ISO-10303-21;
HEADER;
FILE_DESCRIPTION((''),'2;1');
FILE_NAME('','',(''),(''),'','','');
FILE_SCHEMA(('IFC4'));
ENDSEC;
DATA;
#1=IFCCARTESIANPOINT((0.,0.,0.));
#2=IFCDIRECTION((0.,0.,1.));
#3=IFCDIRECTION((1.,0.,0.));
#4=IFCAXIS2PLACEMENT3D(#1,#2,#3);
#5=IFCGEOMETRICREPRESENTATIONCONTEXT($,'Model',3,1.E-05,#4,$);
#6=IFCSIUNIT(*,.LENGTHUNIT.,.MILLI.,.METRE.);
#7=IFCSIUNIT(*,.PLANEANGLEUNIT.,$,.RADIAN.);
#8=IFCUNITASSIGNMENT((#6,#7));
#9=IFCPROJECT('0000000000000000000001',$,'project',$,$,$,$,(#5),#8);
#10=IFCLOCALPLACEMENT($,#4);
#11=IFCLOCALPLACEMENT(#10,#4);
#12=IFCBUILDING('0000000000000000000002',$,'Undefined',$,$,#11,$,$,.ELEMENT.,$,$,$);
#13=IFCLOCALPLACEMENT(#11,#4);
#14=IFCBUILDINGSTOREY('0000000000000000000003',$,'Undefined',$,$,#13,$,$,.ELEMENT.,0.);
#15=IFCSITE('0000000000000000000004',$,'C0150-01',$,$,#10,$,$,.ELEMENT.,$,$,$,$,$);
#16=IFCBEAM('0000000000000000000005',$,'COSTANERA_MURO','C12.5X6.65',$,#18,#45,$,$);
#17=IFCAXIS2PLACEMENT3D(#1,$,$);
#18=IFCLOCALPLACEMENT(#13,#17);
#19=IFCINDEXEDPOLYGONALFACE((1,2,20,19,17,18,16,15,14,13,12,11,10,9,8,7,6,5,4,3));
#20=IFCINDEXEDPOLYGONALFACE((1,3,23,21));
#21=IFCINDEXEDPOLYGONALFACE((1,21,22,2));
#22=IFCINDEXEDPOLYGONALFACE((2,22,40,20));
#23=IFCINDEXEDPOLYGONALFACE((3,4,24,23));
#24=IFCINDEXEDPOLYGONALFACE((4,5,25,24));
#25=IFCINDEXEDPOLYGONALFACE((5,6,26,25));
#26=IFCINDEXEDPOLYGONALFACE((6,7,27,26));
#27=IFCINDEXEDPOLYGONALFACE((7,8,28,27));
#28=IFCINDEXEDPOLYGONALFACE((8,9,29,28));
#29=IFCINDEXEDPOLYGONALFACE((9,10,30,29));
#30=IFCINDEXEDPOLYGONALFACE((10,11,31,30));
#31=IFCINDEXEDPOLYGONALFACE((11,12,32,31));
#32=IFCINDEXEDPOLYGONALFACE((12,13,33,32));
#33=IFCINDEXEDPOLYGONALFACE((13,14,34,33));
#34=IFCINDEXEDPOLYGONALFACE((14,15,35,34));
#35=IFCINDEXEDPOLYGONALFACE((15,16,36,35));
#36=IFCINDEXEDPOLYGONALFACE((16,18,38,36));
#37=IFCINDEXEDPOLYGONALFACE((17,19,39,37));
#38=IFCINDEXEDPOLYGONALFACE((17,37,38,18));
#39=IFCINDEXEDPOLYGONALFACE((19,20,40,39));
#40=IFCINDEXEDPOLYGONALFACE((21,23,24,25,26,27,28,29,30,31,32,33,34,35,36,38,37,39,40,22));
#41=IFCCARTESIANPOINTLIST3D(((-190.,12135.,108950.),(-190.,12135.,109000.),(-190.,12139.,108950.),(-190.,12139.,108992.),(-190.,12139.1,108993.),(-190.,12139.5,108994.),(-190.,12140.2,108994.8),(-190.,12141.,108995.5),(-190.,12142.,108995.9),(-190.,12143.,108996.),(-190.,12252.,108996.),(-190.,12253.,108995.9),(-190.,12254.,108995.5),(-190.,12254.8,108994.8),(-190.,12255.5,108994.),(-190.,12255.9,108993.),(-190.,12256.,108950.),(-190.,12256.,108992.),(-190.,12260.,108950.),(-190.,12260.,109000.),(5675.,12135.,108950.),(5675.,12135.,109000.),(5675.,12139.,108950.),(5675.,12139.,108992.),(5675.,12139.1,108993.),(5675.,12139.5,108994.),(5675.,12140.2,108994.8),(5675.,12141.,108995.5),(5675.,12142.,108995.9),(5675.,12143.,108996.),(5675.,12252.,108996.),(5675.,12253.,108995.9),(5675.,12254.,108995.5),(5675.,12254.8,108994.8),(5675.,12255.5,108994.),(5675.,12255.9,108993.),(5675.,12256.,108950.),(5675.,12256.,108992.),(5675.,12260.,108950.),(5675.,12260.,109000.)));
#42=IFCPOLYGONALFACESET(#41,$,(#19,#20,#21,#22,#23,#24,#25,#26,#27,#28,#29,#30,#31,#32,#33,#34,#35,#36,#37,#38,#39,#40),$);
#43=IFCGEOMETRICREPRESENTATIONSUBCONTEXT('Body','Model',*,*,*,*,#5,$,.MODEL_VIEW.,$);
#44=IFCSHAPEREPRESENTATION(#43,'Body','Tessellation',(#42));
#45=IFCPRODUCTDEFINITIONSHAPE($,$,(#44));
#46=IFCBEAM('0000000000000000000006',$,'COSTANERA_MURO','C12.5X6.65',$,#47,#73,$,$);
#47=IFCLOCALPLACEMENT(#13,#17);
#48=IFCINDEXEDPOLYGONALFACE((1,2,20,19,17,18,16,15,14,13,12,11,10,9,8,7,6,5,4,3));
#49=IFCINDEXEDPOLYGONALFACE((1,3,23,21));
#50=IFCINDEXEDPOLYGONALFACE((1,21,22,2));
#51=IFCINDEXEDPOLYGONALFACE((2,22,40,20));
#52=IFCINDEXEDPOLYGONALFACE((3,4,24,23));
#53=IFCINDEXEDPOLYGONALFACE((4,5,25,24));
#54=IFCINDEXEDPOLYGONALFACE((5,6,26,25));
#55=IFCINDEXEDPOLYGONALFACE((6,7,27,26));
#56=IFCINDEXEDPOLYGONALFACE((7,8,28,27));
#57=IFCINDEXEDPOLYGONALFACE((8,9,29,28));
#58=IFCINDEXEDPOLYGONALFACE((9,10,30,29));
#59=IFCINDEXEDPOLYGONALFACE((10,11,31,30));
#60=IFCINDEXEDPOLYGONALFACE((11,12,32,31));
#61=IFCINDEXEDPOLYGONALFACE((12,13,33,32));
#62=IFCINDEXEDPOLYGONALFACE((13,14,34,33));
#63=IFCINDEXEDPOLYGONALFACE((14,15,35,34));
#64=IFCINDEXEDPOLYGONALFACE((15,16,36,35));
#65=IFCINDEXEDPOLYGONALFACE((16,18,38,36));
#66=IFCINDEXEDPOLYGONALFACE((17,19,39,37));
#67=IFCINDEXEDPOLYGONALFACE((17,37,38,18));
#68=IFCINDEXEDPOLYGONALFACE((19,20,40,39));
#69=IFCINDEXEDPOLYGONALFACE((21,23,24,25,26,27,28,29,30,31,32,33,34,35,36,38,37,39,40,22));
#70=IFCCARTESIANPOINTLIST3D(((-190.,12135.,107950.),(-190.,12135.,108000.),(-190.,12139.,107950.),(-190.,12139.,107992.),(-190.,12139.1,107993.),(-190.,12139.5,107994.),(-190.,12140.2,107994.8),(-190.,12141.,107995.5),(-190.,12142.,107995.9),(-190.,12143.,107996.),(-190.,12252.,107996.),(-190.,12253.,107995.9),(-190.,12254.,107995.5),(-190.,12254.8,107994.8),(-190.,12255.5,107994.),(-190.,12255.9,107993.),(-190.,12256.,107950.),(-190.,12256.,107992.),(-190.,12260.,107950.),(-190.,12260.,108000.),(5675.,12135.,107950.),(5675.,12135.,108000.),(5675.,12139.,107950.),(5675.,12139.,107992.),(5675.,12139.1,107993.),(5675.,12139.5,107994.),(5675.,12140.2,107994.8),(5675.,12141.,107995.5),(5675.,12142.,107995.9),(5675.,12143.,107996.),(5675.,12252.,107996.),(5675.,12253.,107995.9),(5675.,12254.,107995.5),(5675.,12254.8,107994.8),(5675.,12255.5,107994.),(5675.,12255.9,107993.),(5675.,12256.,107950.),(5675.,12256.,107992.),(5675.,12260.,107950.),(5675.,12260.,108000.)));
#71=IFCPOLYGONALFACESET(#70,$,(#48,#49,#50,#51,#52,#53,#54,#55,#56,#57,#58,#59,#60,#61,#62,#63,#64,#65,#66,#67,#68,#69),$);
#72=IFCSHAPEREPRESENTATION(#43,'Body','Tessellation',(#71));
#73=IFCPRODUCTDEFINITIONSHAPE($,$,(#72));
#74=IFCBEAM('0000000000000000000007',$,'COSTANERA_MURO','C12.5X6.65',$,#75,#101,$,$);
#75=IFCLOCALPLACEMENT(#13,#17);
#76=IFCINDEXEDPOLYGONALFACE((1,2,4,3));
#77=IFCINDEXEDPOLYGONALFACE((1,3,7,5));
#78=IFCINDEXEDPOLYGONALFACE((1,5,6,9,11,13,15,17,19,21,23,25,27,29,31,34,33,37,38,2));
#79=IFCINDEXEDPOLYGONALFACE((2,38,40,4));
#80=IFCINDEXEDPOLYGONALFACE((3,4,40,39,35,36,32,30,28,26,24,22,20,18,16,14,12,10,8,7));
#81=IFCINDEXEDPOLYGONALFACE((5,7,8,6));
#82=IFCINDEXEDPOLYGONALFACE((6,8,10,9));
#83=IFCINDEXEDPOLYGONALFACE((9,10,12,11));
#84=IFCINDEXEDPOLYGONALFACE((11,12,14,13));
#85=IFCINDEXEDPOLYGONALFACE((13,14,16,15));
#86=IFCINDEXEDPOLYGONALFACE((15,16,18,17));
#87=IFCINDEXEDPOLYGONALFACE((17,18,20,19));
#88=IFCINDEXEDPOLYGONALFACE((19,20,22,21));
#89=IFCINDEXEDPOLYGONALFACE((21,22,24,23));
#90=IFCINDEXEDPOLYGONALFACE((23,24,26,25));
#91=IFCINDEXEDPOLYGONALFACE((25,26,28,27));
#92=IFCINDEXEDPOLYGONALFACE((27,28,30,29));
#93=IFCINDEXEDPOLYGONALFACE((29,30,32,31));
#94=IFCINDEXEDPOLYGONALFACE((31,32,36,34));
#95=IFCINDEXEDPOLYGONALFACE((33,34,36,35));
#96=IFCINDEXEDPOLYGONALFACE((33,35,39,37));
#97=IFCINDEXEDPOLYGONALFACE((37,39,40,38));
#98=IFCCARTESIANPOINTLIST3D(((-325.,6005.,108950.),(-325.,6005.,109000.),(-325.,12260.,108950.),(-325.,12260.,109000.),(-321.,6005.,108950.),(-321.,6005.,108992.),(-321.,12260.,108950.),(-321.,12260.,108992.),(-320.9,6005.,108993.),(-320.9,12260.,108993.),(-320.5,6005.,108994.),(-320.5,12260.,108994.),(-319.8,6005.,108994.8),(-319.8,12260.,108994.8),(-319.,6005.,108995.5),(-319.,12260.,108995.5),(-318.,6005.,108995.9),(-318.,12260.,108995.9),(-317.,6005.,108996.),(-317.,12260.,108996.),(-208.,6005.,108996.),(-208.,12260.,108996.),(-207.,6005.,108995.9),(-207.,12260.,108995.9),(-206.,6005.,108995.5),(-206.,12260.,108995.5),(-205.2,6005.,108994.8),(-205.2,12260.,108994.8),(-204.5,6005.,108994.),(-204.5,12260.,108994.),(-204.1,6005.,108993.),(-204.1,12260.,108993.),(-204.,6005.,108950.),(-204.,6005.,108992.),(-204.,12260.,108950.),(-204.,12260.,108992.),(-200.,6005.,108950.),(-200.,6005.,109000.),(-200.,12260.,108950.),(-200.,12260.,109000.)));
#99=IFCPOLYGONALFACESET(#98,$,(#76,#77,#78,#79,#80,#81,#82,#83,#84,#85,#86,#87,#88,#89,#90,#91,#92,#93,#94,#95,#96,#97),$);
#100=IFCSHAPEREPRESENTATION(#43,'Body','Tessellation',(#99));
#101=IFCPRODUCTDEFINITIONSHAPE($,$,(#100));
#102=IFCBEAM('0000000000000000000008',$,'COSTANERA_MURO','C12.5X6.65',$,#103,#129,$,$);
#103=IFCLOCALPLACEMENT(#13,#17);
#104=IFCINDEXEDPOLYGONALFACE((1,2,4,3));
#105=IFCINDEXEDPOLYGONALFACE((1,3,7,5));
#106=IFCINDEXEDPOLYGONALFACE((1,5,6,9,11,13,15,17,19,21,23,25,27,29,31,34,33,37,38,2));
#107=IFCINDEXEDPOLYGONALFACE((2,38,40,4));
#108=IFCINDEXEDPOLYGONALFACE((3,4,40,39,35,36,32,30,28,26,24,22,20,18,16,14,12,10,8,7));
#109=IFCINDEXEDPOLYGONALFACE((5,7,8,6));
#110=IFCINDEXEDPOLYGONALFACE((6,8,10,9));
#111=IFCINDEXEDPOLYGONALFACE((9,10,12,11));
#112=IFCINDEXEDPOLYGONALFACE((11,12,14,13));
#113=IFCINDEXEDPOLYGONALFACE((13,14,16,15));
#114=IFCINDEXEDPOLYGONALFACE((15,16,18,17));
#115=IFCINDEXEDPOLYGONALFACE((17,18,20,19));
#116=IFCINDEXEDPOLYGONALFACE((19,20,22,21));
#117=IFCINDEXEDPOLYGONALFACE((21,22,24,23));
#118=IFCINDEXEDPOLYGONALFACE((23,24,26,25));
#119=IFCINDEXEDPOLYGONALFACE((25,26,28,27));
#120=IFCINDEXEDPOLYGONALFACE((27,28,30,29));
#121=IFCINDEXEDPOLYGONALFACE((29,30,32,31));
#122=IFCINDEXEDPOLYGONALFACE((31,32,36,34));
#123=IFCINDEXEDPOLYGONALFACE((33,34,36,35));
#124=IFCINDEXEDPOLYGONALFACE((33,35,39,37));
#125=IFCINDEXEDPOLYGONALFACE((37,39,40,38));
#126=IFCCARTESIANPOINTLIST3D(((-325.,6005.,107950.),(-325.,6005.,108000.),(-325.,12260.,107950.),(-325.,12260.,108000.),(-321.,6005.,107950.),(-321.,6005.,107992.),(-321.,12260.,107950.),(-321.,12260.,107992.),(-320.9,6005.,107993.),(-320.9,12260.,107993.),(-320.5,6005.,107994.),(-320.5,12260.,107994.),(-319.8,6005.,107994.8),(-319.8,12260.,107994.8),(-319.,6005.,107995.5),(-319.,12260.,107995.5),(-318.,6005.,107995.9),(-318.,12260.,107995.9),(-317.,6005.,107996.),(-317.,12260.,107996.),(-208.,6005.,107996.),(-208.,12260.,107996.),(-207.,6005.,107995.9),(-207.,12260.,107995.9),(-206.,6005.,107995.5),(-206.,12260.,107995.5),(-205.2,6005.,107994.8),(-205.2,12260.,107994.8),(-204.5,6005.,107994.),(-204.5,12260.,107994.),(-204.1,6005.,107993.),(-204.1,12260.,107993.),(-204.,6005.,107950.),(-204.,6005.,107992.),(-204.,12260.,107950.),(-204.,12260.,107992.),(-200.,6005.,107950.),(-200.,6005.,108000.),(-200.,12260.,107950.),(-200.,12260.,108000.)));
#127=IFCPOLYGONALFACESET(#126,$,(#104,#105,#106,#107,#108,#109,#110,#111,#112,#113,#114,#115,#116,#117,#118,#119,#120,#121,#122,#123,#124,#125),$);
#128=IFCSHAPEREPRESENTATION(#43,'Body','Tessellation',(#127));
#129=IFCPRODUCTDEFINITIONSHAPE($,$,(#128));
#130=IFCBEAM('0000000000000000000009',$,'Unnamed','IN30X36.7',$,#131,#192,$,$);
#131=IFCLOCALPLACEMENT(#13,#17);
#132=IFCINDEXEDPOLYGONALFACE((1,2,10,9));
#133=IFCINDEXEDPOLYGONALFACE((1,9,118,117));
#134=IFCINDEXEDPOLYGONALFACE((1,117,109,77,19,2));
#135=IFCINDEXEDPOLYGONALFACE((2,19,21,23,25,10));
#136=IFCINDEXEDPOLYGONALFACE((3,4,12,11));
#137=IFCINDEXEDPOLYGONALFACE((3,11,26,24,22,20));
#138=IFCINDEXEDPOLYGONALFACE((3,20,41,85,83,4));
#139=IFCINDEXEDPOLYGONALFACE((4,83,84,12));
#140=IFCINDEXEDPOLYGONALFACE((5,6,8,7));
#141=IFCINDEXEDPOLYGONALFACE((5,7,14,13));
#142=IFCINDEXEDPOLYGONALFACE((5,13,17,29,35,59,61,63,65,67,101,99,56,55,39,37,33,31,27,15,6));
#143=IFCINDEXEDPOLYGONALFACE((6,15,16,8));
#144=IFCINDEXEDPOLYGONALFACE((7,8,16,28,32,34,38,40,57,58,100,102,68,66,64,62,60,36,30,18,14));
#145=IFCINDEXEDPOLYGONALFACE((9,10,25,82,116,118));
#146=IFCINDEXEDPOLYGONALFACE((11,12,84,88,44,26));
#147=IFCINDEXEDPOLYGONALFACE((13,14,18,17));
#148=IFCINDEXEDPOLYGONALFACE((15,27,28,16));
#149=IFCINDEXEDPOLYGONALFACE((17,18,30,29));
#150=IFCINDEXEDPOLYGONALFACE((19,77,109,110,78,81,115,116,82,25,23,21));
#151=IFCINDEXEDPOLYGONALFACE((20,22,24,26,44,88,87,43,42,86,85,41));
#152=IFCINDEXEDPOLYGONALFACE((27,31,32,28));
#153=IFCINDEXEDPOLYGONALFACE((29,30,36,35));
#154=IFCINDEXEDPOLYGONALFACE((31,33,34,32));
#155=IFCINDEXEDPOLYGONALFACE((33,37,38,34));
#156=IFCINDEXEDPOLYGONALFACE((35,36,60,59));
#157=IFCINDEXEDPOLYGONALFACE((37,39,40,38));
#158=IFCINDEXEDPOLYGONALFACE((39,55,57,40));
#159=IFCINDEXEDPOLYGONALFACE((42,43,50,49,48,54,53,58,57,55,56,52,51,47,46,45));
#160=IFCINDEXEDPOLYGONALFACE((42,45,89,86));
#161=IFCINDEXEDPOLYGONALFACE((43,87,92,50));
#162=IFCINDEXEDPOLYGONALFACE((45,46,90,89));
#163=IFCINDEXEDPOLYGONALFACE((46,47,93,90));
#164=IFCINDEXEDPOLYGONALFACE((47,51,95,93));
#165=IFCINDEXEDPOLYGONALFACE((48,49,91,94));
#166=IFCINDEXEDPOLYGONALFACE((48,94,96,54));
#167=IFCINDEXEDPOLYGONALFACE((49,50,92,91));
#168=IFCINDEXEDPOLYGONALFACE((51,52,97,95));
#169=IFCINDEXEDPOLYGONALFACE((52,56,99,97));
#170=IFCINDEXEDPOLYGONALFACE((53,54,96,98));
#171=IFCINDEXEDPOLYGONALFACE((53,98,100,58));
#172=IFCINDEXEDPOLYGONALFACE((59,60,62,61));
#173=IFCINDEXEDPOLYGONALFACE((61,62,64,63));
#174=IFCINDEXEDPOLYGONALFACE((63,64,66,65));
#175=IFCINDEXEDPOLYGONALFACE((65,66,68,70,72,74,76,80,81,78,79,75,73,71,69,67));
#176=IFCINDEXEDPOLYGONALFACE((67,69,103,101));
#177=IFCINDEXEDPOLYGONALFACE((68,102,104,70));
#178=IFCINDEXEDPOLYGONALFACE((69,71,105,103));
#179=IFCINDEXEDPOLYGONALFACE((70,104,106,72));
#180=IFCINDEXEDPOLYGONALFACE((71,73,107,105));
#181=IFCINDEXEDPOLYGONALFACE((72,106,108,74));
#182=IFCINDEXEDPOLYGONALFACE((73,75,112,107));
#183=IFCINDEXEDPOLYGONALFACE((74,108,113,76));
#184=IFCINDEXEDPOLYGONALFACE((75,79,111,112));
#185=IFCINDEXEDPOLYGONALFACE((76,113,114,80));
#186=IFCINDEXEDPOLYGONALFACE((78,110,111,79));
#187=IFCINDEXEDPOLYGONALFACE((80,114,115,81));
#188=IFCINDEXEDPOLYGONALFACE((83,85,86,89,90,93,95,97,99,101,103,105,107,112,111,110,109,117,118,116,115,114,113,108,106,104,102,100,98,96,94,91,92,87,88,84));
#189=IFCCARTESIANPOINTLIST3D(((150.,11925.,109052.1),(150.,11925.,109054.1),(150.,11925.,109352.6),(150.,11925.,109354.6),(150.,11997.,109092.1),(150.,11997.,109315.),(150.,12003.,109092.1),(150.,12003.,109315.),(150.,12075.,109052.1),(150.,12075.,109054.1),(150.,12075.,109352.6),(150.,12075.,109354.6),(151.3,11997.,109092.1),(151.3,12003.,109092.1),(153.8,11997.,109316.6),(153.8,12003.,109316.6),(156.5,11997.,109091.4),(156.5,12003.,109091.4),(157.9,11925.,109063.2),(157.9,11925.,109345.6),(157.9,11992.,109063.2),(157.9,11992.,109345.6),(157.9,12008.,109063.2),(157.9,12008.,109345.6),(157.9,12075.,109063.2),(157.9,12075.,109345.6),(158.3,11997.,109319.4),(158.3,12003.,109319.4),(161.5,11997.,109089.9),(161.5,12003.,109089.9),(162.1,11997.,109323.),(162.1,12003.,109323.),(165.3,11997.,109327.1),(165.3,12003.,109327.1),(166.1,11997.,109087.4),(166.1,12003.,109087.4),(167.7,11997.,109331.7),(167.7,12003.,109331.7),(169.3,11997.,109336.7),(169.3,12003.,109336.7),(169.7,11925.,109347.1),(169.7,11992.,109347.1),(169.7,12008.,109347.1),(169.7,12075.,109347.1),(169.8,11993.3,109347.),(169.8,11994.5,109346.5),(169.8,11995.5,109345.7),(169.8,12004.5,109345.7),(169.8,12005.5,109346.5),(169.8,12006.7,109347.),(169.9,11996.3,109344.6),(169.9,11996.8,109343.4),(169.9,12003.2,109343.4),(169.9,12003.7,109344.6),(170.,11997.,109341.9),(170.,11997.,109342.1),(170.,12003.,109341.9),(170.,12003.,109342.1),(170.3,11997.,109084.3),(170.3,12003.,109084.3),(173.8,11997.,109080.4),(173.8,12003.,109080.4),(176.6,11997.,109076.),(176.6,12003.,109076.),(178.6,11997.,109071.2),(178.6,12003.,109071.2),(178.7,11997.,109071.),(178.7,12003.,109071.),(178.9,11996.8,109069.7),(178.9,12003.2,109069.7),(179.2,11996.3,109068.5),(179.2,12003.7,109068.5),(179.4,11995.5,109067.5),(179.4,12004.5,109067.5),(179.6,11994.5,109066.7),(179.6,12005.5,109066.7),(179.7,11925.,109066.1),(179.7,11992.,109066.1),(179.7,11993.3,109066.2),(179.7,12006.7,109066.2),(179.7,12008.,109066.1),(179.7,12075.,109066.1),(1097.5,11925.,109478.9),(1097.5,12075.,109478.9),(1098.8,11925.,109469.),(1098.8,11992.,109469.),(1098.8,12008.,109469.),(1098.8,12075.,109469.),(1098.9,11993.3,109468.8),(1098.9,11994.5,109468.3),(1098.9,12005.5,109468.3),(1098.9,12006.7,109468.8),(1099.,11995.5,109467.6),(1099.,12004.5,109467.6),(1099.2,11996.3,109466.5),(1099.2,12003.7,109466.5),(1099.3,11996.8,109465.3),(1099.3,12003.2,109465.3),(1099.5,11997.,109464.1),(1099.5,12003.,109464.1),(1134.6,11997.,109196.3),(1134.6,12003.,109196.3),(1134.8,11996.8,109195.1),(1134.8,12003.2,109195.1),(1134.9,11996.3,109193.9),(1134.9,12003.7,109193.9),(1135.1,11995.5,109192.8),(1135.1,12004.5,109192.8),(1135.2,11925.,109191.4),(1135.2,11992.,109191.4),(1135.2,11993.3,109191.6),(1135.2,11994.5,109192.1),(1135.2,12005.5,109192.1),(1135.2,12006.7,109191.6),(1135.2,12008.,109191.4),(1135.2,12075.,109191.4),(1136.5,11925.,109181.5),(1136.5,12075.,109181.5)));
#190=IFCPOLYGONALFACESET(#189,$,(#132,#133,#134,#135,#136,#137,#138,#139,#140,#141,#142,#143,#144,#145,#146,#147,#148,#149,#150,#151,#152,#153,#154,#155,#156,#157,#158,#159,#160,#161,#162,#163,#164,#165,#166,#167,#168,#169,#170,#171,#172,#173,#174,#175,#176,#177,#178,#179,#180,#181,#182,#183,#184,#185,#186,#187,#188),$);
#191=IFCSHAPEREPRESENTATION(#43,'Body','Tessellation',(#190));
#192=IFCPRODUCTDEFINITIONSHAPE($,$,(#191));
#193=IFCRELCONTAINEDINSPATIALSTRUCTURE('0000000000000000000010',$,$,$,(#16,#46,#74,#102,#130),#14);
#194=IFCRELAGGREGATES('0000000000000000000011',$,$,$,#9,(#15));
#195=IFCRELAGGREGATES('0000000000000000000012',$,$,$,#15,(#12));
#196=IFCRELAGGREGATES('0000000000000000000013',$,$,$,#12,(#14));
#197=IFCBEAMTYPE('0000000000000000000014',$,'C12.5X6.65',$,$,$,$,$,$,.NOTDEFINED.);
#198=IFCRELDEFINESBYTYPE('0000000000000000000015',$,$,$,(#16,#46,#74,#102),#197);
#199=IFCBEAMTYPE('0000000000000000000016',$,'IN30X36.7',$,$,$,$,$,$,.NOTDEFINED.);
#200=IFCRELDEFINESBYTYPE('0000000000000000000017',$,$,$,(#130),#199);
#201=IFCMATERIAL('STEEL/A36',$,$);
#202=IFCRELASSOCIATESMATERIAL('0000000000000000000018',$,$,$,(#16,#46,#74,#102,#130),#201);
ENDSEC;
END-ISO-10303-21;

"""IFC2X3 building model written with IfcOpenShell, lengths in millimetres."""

from ifc_helpers import new_model, si_unit, frame, origin_with_axes, origin_2d_with_axis, place, context, subcontext, project, spatial, polyline, i_section, u_section, outline, extrude, boolean, halfspace, material, type_object, element, save


model = new_model("IFC2X3")

# Units and contexts
model_context = context("Model", 3, precision=1e-05, world=origin_with_axes())
body_context = subcontext(model_context, "Body", "Model", "MODEL_VIEW")
ifc_project = project(units=[si_unit("LENGTHUNIT", "METRE", prefix="MILLI"), si_unit("PLANEANGLEUNIT", "RADIAN")], contexts=[model_context])

# Site, building, storey
site_placement = place(None, origin_with_axes())
site = spatial("IfcSite", under=ifc_project, at=site_placement, Name="C0150-01", CompositionType="ELEMENT")
building_placement = place(site_placement, origin_with_axes())
building = spatial("IfcBuilding", under=site, at=building_placement, Name="Undefined", CompositionType="ELEMENT")
storey_placement = place(building_placement, origin_with_axes())
storey = spatial("IfcBuildingStorey", under=building, at=storey_placement, Name="Undefined", CompositionType="ELEMENT", Elevation=0.0)

# Beams
ifc_material_1 = material(Name="STEEL/A36")
beam_type_1 = type_object("IfcBeamType", Name="C12.5X6.65", PredefinedType="NOTDEFINED")
for number, where, z_axis, x_axis, name in (
    (1, (-190.0, 12197.5, 108975.0), (0.0, -1.0, 0.0), (1.0, 0.0, 0.0), "COSTANERA_MURO"),
    (2, (-190.0, 12197.5, 107975.0), (0.0, -1.0, 0.0), (1.0, 0.0, 0.0), "COSTANERA_MURO"),
):
    element("IfcBeam", number, at=place(storey_placement, frame(where, z_axis=z_axis, x_axis=x_axis)), inside=storey, type_object=beam_type_1, material=ifc_material_1, Name=name, Description="C12.5X6.65", context=body_context, shape_type="SweptSolid", body=[
        extrude(u_section(Depth=125.0, FlangeWidth=50.0, WebThickness=4.0, FlangeThickness=4.0, FilletRadius=4.0, at=origin_2d_with_axis()), frame((5865.0, 0.0, 0.0), z_axis=(-1.0, 0.0, 0.0), x_axis=(0.0, -1.0, 0.0)), (0.0, 0.0, 1.0), 5865.0),
    ])
for number, where, z_axis, x_axis, name in (
    (3, (-262.5, 12260.0, 108975.0), (-1.0, 0.0, 0.0), (0.0, -1.0, 0.0), "COSTANERA_MURO"),
    (4, (-262.5, 12260.0, 107975.0), (-1.0, 0.0, 0.0), (0.0, -1.0, 0.0), "COSTANERA_MURO"),
):
    element("IfcBeam", number, at=place(storey_placement, frame(where, z_axis=z_axis, x_axis=x_axis)), inside=storey, type_object=beam_type_1, material=ifc_material_1, Name=name, Description="C12.5X6.65", context=body_context, shape_type="SweptSolid", body=[
        extrude(u_section(Depth=125.0, FlangeWidth=50.0, WebThickness=4.0, FlangeThickness=4.0, FilletRadius=4.0, at=origin_2d_with_axis()), frame((6255.0, 0.0, 0.0), z_axis=(-1.0, 0.0, 0.0), x_axis=(0.0, -1.0, 0.0)), (0.0, 0.0, 1.0), 6255.0),
    ])
beam_type_2 = type_object("IfcBeamType", Name="IN30X36.7", PredefinedType="NOTDEFINED")
beam_1_placement = place(storey_placement, frame((0.0, 12000.0, 109183.7), z_axis=(-0.130054, 0.0, 0.991507), x_axis=(0.991507, 0.0, 0.130054)))
element("IfcBeam", 5, at=beam_1_placement, inside=storey, type_object=beam_type_2, material=ifc_material_1, Name="Unnamed", Description="IN30X36.7", context=body_context, shape_type="CSG", body=[
    boolean("DIFFERENCE", boolean("DIFFERENCE", boolean("DIFFERENCE", boolean("DIFFERENCE", boolean("DIFFERENCE", extrude(i_section(OverallWidth=150.0, OverallDepth=300.0, WebThickness=6.0, FlangeThickness=10.0, FilletRadius=5.0, at=origin_2d_with_axis()), frame((1126.6, 0.0, 0.0), z_axis=(-1.0, 0.0, 0.0), x_axis=(0.0, -1.0, 0.0)), (0.0, 0.0, 1.0), 1126.6), extrude(outline(polyline([(0.0, 0.0), (12.1, 0.0), (9.8, 2.0), (6.0, 5.3), (0.0, 0.0)])), frame((140.9, -77.5, -140.0), z_axis=(0.0, 1.0, 0.0), x_axis=(-0.748593, 0.0, -0.66303)), (0.0, 0.0, 1.0), 155.0)), extrude(outline(polyline([(0.0, 0.0), (8.0, 0.0), (6.9, 8.0), (0.0, 0.0)])), frame((177.6, -77.5, 140.0), z_axis=(0.0, 1.0, 0.0), x_axis=(-1.0, 0.0, 0.0)), (0.0, 0.0, 1.0), 155.0)), extrude(outline(polyline([(0.0, 0.0), (30.0, 0.0), (30.0, 0.0), (29.5, 5.2), (28.2, 10.3), (26.0, 15.0), (23.0, 19.3), (19.3, 23.0), (15.0, 26.0), (10.3, 28.2), (5.2, 29.5), (0.0, 30.0), (3.9, 30.0), (0.0, 0.0)])), frame((159.6, -77.5, 140.0), z_axis=(0.0, 1.0, 0.0), x_axis=(1.0, 0.0, 0.0)), (0.0, 0.0, 1.0), 155.0)), extrude(outline(polyline([(0.0, 0.0), (30.0, 0.0), (30.0, 0.0), (29.5, 5.2), (28.2, 10.3), (26.0, 15.0), (23.0, 19.3), (19.3, 23.0), (15.0, 26.0), (10.3, 28.2), (5.2, 29.5), (0.0, 30.0), (3.9, 30.0), (0.0, 0.0)])), frame((132.9, 77.5, -140.0), z_axis=(0.0, -1.0, 0.0), x_axis=(1.0, 0.0, 0.0)), (0.0, 0.0, 1.0), 155.0)), halfspace(frame((124.8, 0.0, -201.6), z_axis=(0.991507, 0.0, -0.130054), x_axis=(0.0, -1.0, 0.0)), True)),
])

save(model, "model.ifc")
